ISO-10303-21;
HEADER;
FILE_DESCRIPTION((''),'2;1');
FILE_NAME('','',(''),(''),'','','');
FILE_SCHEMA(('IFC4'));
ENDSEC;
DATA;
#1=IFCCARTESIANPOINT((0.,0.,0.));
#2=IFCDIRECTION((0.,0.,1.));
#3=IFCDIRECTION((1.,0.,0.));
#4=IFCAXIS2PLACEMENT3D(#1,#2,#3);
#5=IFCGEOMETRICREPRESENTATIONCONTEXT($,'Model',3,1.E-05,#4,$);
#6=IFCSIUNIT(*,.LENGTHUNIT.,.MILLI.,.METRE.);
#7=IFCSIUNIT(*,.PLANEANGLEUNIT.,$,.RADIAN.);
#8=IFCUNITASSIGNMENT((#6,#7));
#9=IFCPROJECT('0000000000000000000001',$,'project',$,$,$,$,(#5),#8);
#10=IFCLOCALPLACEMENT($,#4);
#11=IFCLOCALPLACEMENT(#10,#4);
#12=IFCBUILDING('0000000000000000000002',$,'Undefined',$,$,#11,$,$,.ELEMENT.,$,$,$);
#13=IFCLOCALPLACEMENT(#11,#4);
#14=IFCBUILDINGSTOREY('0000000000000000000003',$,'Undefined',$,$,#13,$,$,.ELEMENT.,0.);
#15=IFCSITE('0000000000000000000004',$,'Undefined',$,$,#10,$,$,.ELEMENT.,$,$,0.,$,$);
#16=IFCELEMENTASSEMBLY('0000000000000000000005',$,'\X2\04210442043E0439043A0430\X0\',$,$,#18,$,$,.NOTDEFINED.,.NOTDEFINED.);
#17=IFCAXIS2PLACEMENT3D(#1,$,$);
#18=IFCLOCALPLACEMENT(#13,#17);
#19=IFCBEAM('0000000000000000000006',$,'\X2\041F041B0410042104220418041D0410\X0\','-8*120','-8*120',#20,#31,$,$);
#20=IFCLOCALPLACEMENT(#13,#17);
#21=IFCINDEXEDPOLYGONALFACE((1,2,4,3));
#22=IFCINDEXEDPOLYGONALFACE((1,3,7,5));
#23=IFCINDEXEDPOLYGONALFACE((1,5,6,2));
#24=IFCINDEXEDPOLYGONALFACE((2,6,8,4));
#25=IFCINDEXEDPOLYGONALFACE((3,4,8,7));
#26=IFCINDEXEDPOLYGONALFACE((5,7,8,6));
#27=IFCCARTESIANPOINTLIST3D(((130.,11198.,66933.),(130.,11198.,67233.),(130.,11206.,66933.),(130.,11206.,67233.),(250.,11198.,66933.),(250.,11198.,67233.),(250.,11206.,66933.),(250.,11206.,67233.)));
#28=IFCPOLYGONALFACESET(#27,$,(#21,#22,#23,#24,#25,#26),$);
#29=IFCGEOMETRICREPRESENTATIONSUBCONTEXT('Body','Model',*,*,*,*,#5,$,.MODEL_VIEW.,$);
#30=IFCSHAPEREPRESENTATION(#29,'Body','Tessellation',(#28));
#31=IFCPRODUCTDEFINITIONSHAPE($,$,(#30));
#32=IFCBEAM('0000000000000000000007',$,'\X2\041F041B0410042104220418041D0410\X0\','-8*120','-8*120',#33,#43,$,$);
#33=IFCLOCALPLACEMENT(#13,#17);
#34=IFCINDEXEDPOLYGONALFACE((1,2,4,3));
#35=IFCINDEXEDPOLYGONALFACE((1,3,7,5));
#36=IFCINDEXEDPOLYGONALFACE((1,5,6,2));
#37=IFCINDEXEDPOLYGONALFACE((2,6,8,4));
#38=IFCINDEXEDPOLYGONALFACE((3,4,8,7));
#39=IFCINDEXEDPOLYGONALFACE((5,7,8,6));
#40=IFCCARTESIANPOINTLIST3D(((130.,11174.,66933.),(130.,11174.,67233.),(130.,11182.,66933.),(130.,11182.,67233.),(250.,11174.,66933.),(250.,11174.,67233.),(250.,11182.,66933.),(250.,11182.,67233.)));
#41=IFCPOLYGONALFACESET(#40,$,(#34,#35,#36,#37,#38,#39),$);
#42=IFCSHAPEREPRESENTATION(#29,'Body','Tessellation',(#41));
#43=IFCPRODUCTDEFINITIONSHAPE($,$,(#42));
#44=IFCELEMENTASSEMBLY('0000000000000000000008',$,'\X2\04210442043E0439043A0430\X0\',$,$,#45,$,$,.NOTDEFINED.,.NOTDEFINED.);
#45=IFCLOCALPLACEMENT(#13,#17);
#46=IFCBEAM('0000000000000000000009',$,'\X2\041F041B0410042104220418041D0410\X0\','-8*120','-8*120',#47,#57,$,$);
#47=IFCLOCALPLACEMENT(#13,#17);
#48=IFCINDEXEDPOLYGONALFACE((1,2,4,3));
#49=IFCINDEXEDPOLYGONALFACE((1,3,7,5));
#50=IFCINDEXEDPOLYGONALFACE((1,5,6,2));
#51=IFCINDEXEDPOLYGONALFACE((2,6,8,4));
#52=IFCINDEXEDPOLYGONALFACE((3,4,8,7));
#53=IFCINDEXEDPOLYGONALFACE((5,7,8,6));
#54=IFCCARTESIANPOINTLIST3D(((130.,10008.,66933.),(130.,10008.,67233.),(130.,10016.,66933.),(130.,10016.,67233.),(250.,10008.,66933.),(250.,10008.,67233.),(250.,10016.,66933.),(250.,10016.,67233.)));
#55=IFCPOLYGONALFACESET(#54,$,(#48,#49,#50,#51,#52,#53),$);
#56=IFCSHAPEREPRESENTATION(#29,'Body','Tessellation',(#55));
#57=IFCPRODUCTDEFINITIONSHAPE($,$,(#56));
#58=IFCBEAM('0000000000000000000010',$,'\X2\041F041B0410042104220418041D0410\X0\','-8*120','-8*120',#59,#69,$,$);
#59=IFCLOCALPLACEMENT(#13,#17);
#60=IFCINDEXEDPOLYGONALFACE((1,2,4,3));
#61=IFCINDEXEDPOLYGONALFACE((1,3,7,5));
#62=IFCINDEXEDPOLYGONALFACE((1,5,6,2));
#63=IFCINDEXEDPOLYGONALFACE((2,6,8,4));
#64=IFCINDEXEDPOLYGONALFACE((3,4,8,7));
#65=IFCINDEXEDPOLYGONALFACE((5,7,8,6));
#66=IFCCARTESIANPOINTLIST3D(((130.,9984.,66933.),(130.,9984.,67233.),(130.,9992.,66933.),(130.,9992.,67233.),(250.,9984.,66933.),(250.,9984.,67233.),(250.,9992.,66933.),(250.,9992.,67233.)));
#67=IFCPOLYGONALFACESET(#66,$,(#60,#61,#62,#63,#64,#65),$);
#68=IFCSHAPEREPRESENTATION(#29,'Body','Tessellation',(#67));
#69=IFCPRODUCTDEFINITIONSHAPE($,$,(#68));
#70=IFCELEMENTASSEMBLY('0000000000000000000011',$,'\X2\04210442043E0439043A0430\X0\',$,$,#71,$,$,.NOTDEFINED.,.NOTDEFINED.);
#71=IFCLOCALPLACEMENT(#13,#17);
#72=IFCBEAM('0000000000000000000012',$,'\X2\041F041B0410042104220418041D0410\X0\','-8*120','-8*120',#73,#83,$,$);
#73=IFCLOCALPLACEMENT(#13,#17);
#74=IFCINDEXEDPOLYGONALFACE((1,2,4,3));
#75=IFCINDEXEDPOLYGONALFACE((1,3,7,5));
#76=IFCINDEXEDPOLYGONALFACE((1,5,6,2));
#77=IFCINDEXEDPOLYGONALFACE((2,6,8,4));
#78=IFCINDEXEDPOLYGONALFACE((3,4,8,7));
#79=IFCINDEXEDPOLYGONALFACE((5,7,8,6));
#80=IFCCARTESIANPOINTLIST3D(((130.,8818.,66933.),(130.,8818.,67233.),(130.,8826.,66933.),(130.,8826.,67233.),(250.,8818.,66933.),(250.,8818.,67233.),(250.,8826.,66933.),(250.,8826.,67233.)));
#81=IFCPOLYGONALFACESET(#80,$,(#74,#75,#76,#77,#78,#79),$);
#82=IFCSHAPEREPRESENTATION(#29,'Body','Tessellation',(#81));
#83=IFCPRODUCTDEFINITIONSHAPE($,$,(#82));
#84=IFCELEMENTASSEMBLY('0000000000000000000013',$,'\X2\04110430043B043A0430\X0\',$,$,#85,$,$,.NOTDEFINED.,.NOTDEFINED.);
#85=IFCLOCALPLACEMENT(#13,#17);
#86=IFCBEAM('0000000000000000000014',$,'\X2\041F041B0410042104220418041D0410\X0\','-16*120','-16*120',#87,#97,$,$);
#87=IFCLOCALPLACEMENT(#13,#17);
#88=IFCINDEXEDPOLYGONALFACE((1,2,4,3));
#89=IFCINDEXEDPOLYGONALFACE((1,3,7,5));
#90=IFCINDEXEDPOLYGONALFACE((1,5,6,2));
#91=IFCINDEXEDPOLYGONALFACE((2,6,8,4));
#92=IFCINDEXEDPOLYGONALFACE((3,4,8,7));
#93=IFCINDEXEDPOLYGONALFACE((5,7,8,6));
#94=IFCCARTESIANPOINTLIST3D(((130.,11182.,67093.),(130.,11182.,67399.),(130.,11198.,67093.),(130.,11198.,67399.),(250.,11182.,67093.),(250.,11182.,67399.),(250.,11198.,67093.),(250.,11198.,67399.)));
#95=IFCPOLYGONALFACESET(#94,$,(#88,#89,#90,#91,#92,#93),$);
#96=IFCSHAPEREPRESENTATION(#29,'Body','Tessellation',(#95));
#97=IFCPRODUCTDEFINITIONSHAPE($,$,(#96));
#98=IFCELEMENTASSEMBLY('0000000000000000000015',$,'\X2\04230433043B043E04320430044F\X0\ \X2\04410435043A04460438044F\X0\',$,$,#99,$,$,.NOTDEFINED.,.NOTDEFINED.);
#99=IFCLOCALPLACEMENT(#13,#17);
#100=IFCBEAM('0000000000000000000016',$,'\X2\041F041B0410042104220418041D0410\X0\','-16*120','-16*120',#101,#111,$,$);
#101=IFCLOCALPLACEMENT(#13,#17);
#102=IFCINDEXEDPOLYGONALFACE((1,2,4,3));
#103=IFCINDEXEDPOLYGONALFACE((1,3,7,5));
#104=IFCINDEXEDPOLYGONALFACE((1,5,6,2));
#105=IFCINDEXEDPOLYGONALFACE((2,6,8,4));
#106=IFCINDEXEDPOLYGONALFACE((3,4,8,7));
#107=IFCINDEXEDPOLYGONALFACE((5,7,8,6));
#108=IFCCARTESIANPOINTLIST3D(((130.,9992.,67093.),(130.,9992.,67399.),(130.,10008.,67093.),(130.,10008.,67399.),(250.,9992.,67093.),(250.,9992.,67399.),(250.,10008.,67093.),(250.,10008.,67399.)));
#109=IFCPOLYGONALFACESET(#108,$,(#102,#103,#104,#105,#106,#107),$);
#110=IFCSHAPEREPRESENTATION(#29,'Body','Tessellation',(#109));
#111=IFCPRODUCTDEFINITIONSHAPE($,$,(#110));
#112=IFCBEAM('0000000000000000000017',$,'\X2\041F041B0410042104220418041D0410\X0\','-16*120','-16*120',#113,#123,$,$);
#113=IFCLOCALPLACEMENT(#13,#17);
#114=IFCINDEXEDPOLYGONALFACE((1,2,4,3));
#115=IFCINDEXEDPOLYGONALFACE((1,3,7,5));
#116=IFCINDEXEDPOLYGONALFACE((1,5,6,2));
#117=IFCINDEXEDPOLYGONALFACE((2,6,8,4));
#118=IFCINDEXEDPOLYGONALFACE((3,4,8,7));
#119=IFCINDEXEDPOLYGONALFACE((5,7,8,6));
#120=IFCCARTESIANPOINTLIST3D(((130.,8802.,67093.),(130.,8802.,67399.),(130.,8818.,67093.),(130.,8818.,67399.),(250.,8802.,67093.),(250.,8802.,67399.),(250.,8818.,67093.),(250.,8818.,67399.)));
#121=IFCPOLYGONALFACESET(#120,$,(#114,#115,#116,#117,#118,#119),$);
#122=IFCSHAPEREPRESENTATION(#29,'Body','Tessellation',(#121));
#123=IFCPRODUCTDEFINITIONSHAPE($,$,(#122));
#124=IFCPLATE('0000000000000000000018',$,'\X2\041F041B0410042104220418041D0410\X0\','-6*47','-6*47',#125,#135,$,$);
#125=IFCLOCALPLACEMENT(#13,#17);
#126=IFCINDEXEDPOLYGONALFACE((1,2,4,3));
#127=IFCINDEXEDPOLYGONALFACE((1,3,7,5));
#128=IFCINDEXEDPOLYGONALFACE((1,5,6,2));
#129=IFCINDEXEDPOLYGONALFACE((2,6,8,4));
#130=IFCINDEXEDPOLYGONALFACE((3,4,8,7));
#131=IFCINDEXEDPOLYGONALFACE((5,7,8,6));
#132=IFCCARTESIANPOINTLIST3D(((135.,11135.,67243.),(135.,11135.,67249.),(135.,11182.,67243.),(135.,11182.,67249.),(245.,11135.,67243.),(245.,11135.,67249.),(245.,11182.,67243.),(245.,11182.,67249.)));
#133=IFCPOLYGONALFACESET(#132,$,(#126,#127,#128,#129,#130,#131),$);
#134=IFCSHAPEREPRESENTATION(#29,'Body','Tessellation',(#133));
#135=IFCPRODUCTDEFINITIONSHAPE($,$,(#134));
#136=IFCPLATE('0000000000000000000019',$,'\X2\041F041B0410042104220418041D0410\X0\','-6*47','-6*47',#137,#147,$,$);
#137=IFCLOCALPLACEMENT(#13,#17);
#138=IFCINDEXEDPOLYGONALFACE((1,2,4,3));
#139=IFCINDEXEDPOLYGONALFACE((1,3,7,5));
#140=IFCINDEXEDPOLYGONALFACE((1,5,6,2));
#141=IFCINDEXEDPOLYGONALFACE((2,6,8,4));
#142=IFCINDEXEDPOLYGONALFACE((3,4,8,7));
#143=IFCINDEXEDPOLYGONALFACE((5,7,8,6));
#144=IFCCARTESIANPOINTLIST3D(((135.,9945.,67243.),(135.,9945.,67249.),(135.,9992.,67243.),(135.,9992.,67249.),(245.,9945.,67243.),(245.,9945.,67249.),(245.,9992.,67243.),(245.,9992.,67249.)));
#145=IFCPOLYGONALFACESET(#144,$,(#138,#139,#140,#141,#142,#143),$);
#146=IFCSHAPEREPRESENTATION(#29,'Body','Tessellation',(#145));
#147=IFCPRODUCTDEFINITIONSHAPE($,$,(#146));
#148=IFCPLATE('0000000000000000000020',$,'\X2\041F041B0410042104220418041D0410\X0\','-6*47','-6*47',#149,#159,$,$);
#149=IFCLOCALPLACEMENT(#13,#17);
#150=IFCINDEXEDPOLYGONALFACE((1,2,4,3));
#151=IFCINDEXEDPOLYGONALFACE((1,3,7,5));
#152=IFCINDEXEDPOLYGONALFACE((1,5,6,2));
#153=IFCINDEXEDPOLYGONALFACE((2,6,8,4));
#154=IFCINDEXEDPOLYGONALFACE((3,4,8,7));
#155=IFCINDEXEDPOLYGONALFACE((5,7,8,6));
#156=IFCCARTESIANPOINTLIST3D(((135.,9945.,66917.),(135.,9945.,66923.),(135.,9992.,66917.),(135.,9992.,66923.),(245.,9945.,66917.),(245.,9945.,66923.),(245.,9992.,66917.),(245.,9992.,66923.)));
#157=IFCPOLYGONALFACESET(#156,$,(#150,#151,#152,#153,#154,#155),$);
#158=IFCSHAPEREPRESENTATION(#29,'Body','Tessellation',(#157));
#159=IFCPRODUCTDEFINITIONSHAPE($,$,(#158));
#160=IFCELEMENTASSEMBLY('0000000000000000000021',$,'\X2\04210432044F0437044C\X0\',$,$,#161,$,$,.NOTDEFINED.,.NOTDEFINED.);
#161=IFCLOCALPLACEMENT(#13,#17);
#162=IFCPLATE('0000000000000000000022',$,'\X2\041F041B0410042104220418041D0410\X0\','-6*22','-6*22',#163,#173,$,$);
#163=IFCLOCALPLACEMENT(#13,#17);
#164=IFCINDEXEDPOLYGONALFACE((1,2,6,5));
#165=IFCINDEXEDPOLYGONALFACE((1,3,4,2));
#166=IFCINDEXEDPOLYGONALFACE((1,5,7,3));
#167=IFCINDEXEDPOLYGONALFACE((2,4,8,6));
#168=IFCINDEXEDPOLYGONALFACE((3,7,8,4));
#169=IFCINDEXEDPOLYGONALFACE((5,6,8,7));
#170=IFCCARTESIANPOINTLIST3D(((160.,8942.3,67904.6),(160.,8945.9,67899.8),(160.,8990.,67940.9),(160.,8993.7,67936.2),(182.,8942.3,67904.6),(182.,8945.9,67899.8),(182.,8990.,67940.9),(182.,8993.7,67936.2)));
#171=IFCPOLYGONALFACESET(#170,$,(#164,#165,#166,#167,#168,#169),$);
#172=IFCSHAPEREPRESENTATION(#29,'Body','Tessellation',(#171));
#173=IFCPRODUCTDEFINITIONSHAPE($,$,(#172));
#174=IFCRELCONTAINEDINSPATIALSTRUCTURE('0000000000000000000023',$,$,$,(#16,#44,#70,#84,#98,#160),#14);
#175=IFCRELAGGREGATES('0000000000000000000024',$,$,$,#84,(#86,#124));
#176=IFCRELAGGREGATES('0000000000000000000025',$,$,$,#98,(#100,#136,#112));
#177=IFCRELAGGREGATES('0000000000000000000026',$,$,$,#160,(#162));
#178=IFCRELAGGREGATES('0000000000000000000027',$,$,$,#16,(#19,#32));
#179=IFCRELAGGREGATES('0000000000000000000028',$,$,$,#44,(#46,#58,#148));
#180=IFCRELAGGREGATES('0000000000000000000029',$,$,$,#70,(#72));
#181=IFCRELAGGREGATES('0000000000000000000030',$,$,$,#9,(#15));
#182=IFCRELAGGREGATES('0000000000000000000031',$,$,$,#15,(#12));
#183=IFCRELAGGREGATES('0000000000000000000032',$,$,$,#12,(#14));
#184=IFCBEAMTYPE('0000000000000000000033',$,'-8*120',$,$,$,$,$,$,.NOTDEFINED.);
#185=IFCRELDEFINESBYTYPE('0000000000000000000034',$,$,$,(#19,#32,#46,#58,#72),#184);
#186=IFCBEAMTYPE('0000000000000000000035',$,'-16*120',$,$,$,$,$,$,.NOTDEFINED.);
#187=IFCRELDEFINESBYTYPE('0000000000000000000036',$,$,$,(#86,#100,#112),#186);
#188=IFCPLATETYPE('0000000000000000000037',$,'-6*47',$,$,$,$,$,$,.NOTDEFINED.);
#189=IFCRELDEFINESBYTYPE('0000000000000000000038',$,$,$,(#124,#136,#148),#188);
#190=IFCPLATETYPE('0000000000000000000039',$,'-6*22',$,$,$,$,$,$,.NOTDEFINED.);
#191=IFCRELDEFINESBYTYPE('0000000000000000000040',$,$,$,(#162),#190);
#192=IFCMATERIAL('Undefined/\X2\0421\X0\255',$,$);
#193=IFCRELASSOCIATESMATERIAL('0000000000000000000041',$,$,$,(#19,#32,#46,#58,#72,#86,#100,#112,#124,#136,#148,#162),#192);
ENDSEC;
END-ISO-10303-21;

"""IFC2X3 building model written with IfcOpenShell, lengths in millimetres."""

from ifc_helpers import new_model, si_unit, frame, origin_with_axes, origin_2d_with_axis, place, context, subcontext, project, spatial, polyline, rectangle, outline, extrude, boolean, material, type_object, element, aggregate, save


model = new_model("IFC2X3")

# Units and contexts
model_context = context("Model", 3, precision=1e-05, world=origin_with_axes())
body_context = subcontext(model_context, "Body", "Model", "MODEL_VIEW")
ifc_project = project(units=[si_unit("LENGTHUNIT", "METRE", prefix="MILLI"), si_unit("PLANEANGLEUNIT", "RADIAN")], contexts=[model_context])

# Site, building, storey
site_placement = place(None, origin_with_axes())
site = spatial("IfcSite", under=ifc_project, at=site_placement, Name="Undefined", CompositionType="ELEMENT", RefElevation=0.0)
building_placement = place(site_placement, origin_with_axes())
building = spatial("IfcBuilding", under=site, at=building_placement, Name="Undefined", CompositionType="ELEMENT")
storey_placement = place(building_placement, origin_with_axes())
storey = spatial("IfcBuildingStorey", under=building, at=storey_placement, Name="Undefined", CompositionType="ELEMENT", Elevation=0.0)

# Element assemblies, beams
assembly_1_placement = place(storey_placement, origin_with_axes())
assembly_1 = element("IfcElementAssembly", 1, at=assembly_1_placement, inside=storey, Name="Стойка", AssemblyPlace="NOTDEFINED", PredefinedType="NOTDEFINED")
ifc_material_1 = material(Name="Undefined/С255")
beam_type_1 = type_object("IfcBeamType", Name="-8*120", PredefinedType="NOTDEFINED")
beam_1_placement = place(assembly_1_placement, frame((190.0, 11202.0, 66933.0), z_axis=(1.0, 0.0, 0.0), x_axis=(0.0, 0.0, 1.0)))
beam_1 = element("IfcBeam", 2, at=beam_1_placement, type_object=beam_type_1, material=ifc_material_1, Name="ПЛАСТИНА", Description="-8*120", ObjectType="-8*120", context=body_context, shape_type="SweptSolid", body=[
    extrude(rectangle(XDim=8.0, YDim=120.0, at=origin_2d_with_axis()), frame((300.0, 0.0, 0.0), z_axis=(-1.0, 0.0, 0.0), x_axis=(0.0, -1.0, 0.0)), (0.0, 0.0, 1.0), 300.0),
])
beam_2_placement = place(assembly_1_placement, frame((190.0, 11178.0, 66933.0), z_axis=(1.0, 0.0, 0.0), x_axis=(0.0, 0.0, 1.0)))
beam_2 = element("IfcBeam", 3, at=beam_2_placement, type_object=beam_type_1, material=ifc_material_1, Name="ПЛАСТИНА", Description="-8*120", ObjectType="-8*120", context=body_context, shape_type="SweptSolid", body=[
    extrude(rectangle(XDim=8.0, YDim=120.0, at=origin_2d_with_axis()), frame((300.0, 0.0, 0.0), z_axis=(-1.0, 0.0, 0.0), x_axis=(0.0, -1.0, 0.0)), (0.0, 0.0, 1.0), 300.0),
])
assembly_2_placement = place(storey_placement, origin_with_axes())
assembly_2 = element("IfcElementAssembly", 4, at=assembly_2_placement, inside=storey, Name="Стойка", AssemblyPlace="NOTDEFINED", PredefinedType="NOTDEFINED")
beam_3_placement = place(assembly_2_placement, frame((190.0, 10012.0, 66933.0), z_axis=(1.0, 0.0, 0.0), x_axis=(0.0, 0.0, 1.0)))
beam_3 = element("IfcBeam", 5, at=beam_3_placement, type_object=beam_type_1, material=ifc_material_1, Name="ПЛАСТИНА", Description="-8*120", ObjectType="-8*120", context=body_context, shape_type="SweptSolid", body=[
    extrude(rectangle(XDim=8.0, YDim=120.0, at=origin_2d_with_axis()), frame((300.0, 0.0, 0.0), z_axis=(-1.0, 0.0, 0.0), x_axis=(0.0, -1.0, 0.0)), (0.0, 0.0, 1.0), 300.0),
])
beam_4_placement = place(assembly_2_placement, frame((190.0, 9988.0, 66933.0), z_axis=(1.0, 0.0, 0.0), x_axis=(0.0, 0.0, 1.0)))
beam_4 = element("IfcBeam", 6, at=beam_4_placement, type_object=beam_type_1, material=ifc_material_1, Name="ПЛАСТИНА", Description="-8*120", ObjectType="-8*120", context=body_context, shape_type="SweptSolid", body=[
    extrude(rectangle(XDim=8.0, YDim=120.0, at=origin_2d_with_axis()), frame((300.0, 0.0, 0.0), z_axis=(-1.0, 0.0, 0.0), x_axis=(0.0, -1.0, 0.0)), (0.0, 0.0, 1.0), 300.0),
])

# Element assemblies, beams
assembly_3_placement = place(storey_placement, origin_with_axes())
assembly_3 = element("IfcElementAssembly", 7, at=assembly_3_placement, inside=storey, Name="Стойка", AssemblyPlace="NOTDEFINED", PredefinedType="NOTDEFINED")
beam_5_placement = place(assembly_3_placement, frame((190.0, 8822.0, 66933.0), z_axis=(1.0, 0.0, 0.0), x_axis=(0.0, 0.0, 1.0)))
beam_5 = element("IfcBeam", 8, at=beam_5_placement, type_object=beam_type_1, material=ifc_material_1, Name="ПЛАСТИНА", Description="-8*120", ObjectType="-8*120", context=body_context, shape_type="SweptSolid", body=[
    extrude(rectangle(XDim=8.0, YDim=120.0, at=origin_2d_with_axis()), frame((300.0, 0.0, 0.0), z_axis=(-1.0, 0.0, 0.0), x_axis=(0.0, -1.0, 0.0)), (0.0, 0.0, 1.0), 300.0),
])
assembly_4_placement = place(storey_placement, origin_with_axes())
assembly_4 = element("IfcElementAssembly", 9, at=assembly_4_placement, inside=storey, Name="Балка", AssemblyPlace="NOTDEFINED", PredefinedType="NOTDEFINED")
beam_type_2 = type_object("IfcBeamType", Name="-16*120", PredefinedType="NOTDEFINED")
beam_6_placement = place(assembly_4_placement, frame((190.0, 11190.0, 67093.0), z_axis=(1.0, 0.0, 0.0), x_axis=(0.0, 0.0, 1.0)))
beam_6 = element("IfcBeam", 10, at=beam_6_placement, type_object=beam_type_2, material=ifc_material_1, Name="ПЛАСТИНА", Description="-16*120", ObjectType="-16*120", context=body_context, shape_type="SweptSolid", body=[
    extrude(rectangle(XDim=16.0, YDim=120.0, at=origin_2d_with_axis()), frame((306.0, 0.0, 0.0), z_axis=(-1.0, 0.0, 0.0), x_axis=(0.0, -1.0, 0.0)), (0.0, 0.0, 1.0), 306.0),
])

# Element assembly, beams
assembly_5_placement = place(storey_placement, origin_with_axes())
assembly_5 = element("IfcElementAssembly", 11, at=assembly_5_placement, inside=storey, Name="Угловая секция", AssemblyPlace="NOTDEFINED", PredefinedType="NOTDEFINED")
beam_7_placement = place(assembly_5_placement, frame((190.0, 10000.0, 67093.0), z_axis=(1.0, 0.0, 0.0), x_axis=(0.0, 0.0, 1.0)))
beam_7 = element("IfcBeam", 12, at=beam_7_placement, type_object=beam_type_2, material=ifc_material_1, Name="ПЛАСТИНА", Description="-16*120", ObjectType="-16*120", context=body_context, shape_type="SweptSolid", body=[
    extrude(rectangle(XDim=16.0, YDim=120.0, at=origin_2d_with_axis()), frame((306.0, 0.0, 0.0), z_axis=(-1.0, 0.0, 0.0), x_axis=(0.0, -1.0, 0.0)), (0.0, 0.0, 1.0), 306.0),
])
beam_8_placement = place(assembly_5_placement, frame((190.0, 8810.0, 67093.0), z_axis=(1.0, 0.0, 0.0), x_axis=(0.0, 0.0, 1.0)))
beam_8 = element("IfcBeam", 13, at=beam_8_placement, type_object=beam_type_2, material=ifc_material_1, Name="ПЛАСТИНА", Description="-16*120", ObjectType="-16*120", context=body_context, shape_type="SweptSolid", body=[
    extrude(rectangle(XDim=16.0, YDim=120.0, at=origin_2d_with_axis()), frame((306.0, 0.0, 0.0), z_axis=(-1.0, 0.0, 0.0), x_axis=(0.0, -1.0, 0.0)), (0.0, 0.0, 1.0), 306.0),
])

# Plates
plate_type_1 = type_object("IfcPlateType", Name="-6*47", PredefinedType="NOTDEFINED")
plate_1_placement = place(assembly_4_placement, frame((245.0, 11135.0, 67246.0), z_axis=(0.0, 0.0, -1.0), x_axis=(-1.0, 0.0, 0.0)))
plate_1 = element("IfcPlate", 14, at=plate_1_placement, type_object=plate_type_1, material=ifc_material_1, Name="ПЛАСТИНА", Description="-6*47", ObjectType="-6*47", context=body_context, shape_type="CSG", body=[
    boolean("DIFFERENCE", extrude(outline(polyline([(0.0, 0.0), (110.0, 0.0), (110.0, 110.0), (0.0, 110.0), (0.0, 0.0)])), frame((0.0, 0.0, -3.0), z_axis=(0.0, 0.0, 1.0), x_axis=(1.0, 0.0, 0.0)), (0.0, 0.0, 1.0), 6.0), extrude(rectangle(XDim=26.0, YDim=130.0, at=origin_2d_with_axis()), frame((55.0, 47.0, 0.0), z_axis=(0.0, 1.0, 0.0), x_axis=(0.0, 0.0, -1.0)), (0.0, 0.0, 1.0), 66.0)),
])
aggregate(assembly_4, [beam_6, plate_1])
plate_2_placement = place(assembly_5_placement, frame((245.0, 9945.0, 67246.0), z_axis=(0.0, 0.0, -1.0), x_axis=(-1.0, 0.0, 0.0)))
plate_2 = element("IfcPlate", 15, at=plate_2_placement, type_object=plate_type_1, material=ifc_material_1, Name="ПЛАСТИНА", Description="-6*47", ObjectType="-6*47", context=body_context, shape_type="CSG", body=[
    boolean("DIFFERENCE", extrude(outline(polyline([(0.0, 0.0), (110.0, 0.0), (110.0, 110.0), (0.0, 110.0), (0.0, 0.0)])), frame((0.0, 0.0, -3.0), z_axis=(0.0, 0.0, 1.0), x_axis=(1.0, 0.0, 0.0)), (0.0, 0.0, 1.0), 6.0), extrude(rectangle(XDim=26.0, YDim=130.0, at=origin_2d_with_axis()), frame((55.0, 47.0, 0.0), z_axis=(0.0, 1.0, 0.0), x_axis=(0.0, 0.0, -1.0)), (0.0, 0.0, 1.0), 66.0)),
])
aggregate(assembly_5, [beam_7, plate_2, beam_8])
plate_3_placement = place(assembly_2_placement, frame((135.0, 9945.0, 66920.0), z_axis=(0.0, 0.0, 1.0), x_axis=(1.0, 0.0, 0.0)))
plate_3 = element("IfcPlate", 16, at=plate_3_placement, type_object=plate_type_1, material=ifc_material_1, Name="ПЛАСТИНА", Description="-6*47", ObjectType="-6*47", context=body_context, shape_type="CSG", body=[
    boolean("DIFFERENCE", extrude(outline(polyline([(0.0, 0.0), (110.0, 0.0), (110.0, 110.0), (0.0, 110.0), (0.0, 0.0)])), frame((0.0, 0.0, -3.0), z_axis=(0.0, 0.0, 1.0), x_axis=(1.0, 0.0, 0.0)), (0.0, 0.0, 1.0), 6.0), extrude(rectangle(XDim=26.0, YDim=130.0, at=origin_2d_with_axis()), frame((55.0, 47.0, 0.0), z_axis=(0.0, 1.0, 0.0), x_axis=(0.0, 0.0, -1.0)), (0.0, 0.0, 1.0), 66.0)),
])

# Element assembly, plate
assembly_6_placement = place(storey_placement, origin_with_axes())
assembly_6 = element("IfcElementAssembly", 17, at=assembly_6_placement, inside=storey, Name="Связь", AssemblyPlace="NOTDEFINED", PredefinedType="NOTDEFINED")
plate_type_2 = type_object("IfcPlateType", Name="-6*22", PredefinedType="NOTDEFINED")
plate_4_placement = place(assembly_6_placement, frame((182.0, 8944.1, 67902.2), z_axis=(0.0, 0.606043, -0.795432), x_axis=(-1.0, 0.0, 0.0)))
plate_4 = element("IfcPlate", 18, at=plate_4_placement, type_object=plate_type_2, material=ifc_material_1, Name="ПЛАСТИНА", Description="-6*22", ObjectType="-6*22", context=body_context, shape_type="SweptSolid", body=[
    extrude(outline(polyline([(0.0, 0.0), (22.0, 0.0), (22.0, 60.0), (0.0, 60.0), (0.0, 0.0)])), frame((0.0, 0.0, -3.0), z_axis=(0.0, 0.0, 1.0), x_axis=(1.0, 0.0, 0.0)), (0.0, 0.0, 1.0), 6.0),
])
aggregate(assembly_6, [plate_4])

aggregate(assembly_1, [beam_1, beam_2])
aggregate(assembly_2, [beam_3, beam_4, plate_3])
aggregate(assembly_3, [beam_5])

save(model, "model.ifc")
